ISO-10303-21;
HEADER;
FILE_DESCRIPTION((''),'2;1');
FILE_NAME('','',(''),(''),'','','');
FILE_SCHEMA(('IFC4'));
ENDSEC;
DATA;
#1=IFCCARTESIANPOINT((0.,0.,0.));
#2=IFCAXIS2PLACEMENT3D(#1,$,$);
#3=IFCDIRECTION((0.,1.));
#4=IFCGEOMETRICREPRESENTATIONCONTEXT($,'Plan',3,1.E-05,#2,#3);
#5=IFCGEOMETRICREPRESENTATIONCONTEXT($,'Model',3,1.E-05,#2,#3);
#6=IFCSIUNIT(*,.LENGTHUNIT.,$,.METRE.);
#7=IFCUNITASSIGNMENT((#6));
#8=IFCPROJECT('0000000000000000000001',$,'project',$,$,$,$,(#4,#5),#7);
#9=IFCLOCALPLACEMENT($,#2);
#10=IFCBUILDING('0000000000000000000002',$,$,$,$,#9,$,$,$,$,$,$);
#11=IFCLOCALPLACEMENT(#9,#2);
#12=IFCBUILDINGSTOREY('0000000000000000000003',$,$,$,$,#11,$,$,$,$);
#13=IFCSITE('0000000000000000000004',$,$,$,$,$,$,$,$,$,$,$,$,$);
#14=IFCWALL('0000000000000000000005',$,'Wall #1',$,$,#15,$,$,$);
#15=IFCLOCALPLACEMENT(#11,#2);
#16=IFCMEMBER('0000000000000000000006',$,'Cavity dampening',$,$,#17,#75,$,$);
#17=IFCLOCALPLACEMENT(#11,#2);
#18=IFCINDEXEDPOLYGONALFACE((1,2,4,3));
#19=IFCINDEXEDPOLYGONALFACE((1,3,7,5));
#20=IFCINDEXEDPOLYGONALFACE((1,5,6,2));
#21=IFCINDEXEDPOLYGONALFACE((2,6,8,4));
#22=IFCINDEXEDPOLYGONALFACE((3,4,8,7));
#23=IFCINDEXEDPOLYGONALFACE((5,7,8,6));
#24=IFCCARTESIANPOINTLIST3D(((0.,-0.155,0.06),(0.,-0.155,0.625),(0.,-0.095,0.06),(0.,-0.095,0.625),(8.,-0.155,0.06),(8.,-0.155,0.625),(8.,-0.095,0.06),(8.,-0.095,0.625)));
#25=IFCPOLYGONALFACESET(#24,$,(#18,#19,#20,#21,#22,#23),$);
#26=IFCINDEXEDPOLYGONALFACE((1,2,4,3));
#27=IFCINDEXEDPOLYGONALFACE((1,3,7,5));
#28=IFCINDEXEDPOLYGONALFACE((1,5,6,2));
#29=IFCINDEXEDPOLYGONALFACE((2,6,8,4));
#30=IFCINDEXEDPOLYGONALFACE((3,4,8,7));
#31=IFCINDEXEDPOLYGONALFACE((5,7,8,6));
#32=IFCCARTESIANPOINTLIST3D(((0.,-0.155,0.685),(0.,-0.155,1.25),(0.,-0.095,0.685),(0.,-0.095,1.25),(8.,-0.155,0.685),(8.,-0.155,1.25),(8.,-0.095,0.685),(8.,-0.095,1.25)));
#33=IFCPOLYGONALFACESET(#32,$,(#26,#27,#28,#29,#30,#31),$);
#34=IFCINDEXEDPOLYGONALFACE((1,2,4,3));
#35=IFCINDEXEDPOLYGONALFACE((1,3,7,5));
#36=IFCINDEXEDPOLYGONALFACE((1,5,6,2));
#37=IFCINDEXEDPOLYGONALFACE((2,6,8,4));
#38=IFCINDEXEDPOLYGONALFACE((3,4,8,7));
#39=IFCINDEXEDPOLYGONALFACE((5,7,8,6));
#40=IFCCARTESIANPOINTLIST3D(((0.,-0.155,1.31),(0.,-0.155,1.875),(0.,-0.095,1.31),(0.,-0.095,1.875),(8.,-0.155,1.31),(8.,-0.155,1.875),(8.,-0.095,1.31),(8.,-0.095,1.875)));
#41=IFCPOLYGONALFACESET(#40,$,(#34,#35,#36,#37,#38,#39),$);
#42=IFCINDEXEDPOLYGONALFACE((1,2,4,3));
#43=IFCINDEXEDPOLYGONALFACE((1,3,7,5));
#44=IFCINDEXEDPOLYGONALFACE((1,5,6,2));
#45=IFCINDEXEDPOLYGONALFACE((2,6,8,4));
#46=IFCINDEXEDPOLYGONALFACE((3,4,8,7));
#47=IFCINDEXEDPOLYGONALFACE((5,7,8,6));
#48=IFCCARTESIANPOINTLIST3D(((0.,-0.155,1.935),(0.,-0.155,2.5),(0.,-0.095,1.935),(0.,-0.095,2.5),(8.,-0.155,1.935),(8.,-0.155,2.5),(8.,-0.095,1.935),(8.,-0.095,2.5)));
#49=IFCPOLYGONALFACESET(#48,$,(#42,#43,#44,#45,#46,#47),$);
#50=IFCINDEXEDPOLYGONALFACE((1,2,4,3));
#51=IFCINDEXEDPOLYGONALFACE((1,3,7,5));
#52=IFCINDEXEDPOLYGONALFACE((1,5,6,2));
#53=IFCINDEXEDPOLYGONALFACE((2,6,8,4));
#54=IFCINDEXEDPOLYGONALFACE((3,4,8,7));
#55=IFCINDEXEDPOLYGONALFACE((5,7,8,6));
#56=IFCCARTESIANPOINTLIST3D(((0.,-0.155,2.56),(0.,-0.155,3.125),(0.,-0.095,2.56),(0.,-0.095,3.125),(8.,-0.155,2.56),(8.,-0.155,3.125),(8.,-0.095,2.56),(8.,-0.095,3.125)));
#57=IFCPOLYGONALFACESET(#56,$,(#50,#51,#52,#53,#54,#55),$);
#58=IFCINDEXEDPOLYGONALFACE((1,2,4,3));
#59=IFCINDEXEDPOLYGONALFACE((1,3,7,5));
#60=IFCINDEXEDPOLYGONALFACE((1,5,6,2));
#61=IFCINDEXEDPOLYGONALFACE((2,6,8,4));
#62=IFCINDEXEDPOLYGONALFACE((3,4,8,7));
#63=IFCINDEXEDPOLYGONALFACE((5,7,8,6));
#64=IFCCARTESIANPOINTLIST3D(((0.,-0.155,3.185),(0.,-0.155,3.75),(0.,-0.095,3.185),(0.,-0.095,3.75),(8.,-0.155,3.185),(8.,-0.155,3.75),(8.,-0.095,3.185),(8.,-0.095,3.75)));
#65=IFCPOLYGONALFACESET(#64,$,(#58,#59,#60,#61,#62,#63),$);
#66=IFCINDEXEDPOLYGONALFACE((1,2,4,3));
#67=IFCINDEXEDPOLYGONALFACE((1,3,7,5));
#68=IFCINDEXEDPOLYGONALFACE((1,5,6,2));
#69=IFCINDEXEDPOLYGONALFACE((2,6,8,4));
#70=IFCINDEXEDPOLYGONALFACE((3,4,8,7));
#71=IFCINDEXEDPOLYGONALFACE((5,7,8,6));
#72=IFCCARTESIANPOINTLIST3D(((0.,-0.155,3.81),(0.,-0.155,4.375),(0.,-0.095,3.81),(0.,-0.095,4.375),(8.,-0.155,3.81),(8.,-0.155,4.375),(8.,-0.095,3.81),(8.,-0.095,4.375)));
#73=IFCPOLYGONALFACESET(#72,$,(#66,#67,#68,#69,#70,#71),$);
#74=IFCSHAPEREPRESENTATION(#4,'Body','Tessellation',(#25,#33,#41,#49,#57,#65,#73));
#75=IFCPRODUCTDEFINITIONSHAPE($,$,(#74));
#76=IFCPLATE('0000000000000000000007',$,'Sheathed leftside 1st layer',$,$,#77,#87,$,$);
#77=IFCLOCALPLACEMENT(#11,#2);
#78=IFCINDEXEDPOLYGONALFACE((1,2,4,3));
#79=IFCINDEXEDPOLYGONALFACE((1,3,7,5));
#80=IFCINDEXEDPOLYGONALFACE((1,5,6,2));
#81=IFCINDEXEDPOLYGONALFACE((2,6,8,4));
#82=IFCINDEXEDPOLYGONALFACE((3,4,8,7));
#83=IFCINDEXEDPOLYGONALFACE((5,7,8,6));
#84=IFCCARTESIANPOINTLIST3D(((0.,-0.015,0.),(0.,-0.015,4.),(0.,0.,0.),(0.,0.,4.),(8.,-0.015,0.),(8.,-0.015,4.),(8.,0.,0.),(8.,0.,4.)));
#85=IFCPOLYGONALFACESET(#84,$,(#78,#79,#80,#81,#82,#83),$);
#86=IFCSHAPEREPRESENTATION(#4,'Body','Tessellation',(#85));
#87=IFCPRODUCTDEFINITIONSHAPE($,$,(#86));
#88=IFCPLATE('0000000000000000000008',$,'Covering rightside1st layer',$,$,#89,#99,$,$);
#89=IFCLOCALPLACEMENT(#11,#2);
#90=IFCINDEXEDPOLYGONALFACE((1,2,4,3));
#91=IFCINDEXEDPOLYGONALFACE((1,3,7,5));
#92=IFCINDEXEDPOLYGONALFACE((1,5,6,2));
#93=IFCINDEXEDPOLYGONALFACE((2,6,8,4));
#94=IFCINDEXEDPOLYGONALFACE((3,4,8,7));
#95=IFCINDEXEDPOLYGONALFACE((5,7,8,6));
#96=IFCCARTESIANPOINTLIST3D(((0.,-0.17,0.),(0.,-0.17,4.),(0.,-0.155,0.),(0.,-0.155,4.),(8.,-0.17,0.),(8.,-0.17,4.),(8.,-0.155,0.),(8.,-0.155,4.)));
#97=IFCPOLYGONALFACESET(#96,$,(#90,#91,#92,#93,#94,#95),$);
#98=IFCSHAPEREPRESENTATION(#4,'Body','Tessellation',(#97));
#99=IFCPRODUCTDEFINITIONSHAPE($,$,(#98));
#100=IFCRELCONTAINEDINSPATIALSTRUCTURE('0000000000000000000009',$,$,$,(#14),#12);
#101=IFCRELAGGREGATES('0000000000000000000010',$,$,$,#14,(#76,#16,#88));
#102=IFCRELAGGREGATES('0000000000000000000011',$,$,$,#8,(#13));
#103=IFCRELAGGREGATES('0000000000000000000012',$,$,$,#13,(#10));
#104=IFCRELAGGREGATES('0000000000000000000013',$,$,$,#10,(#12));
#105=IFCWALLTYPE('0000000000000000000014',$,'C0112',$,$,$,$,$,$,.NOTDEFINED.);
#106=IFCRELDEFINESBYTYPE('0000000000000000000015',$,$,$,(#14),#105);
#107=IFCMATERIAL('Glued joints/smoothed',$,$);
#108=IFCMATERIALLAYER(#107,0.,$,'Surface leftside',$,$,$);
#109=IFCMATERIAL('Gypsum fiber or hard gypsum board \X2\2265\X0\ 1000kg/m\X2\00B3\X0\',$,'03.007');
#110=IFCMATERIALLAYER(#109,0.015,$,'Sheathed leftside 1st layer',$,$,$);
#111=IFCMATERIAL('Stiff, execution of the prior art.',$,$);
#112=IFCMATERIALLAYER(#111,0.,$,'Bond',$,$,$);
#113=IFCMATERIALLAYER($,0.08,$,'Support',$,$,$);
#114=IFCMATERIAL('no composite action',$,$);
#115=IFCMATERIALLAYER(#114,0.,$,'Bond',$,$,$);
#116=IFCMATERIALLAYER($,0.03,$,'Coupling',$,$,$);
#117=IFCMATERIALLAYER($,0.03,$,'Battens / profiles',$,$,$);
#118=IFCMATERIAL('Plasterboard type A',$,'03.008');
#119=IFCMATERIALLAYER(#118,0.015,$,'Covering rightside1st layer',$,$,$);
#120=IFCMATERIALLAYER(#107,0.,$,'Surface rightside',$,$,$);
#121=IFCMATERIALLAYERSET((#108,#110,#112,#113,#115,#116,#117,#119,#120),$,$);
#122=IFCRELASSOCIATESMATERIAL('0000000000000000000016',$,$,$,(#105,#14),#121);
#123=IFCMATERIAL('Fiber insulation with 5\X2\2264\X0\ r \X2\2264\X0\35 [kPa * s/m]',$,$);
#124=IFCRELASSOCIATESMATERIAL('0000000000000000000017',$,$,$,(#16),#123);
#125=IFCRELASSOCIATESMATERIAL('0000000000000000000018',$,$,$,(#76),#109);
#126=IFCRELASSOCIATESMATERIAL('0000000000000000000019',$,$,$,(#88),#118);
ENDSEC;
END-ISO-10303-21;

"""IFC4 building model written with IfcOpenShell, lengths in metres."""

from ifc_helpers import new_model, si_unit, direction, frame, frame_2d, origin, origin_with_axes, place, context, project, spatial, rectangle, extrude, material, layer, layer_set, type_object, element, aggregate, save


model = new_model("IFC4")

# Units and contexts
plan_context = context("Plan", 3, precision=1e-05, world=origin(), true_north=direction((0.0, 1.0)))
model_context = context("Model", 3, precision=1e-05, world=origin(), true_north=direction((0.0, 1.0)))
ifc_project = project(units=[si_unit("LENGTHUNIT", "METRE")], contexts=[plan_context, model_context])

# Site, building, storey
site = spatial("IfcSite", under=ifc_project)
building_placement = place(None, origin())
building = spatial("IfcBuilding", under=site, at=building_placement)
storey_placement = place(building_placement, origin())
storey = spatial("IfcBuildingStorey", under=building, at=storey_placement)

# Wall, member, plates
ifc_material_1 = material(Name="Glued joints/smoothed")
ifc_layer_1 = layer(ifc_material_1, 0.0, Name="Surface leftside")
ifc_material_2 = material(Name="Gypsum fiber or hard gypsum board ≥ 1000kg/m³", Category="03.007")
ifc_layer_2 = layer(ifc_material_2, 0.015, Name="Sheathed leftside 1st layer")
ifc_material_3 = material(Name="Stiff, execution of the prior art.")
ifc_layer_3 = layer(ifc_material_3, 0.0, Name="Bond")
ifc_layer_4 = layer(None, 0.08, Name="Support")
ifc_material_4 = material(Name="no composite action")
ifc_layer_5 = layer(ifc_material_4, 0.0, Name="Bond")
ifc_layer_6 = layer(None, 0.03, Name="Coupling")
ifc_layer_7 = layer(None, 0.03, Name="Battens / profiles")
ifc_material_5 = material(Name="Plasterboard type A", Category="03.008")
ifc_layer_8 = layer(ifc_material_5, 0.015, Name="Covering rightside1st layer")
ifc_layer_9 = layer(ifc_material_1, 0.0, Name="Surface rightside")
ifc_layer_set = layer_set([ifc_layer_1, ifc_layer_2, ifc_layer_3, ifc_layer_4, ifc_layer_5, ifc_layer_6, ifc_layer_7, ifc_layer_8, ifc_layer_9])
wall_type = type_object("IfcWallType", Name="C0112", PredefinedType="NOTDEFINED", material=ifc_layer_set)
wall_placement = place(None, frame((0.0, 0.0, 0.0), z_axis=(0.0, -1.0, 0.0), x_axis=(1.0, 0.0, 0.0)))
wall = element("IfcWall", 1, at=wall_placement, inside=storey, type_object=wall_type, material=ifc_layer_set, Name="Wall #1")
ifc_material_6 = material(Name="Fiber insulation with 5≤ r ≤35 [kPa * s/m]")
member_1_placement = place(wall_placement, origin())
member_1 = element("IfcMember", 2, at=member_1_placement, material=ifc_material_6, Name="Cavity dampening", context=plan_context, shape_type="SweptSolid", body=[
    extrude(rectangle(XDim=0.565, YDim=0.06, at=frame_2d((0.2825, 0.03), x_axis=(1.0, 0.0))), frame((0.0, 0.06, 0.095), z_axis=(1.0, 0.0, 0.0), x_axis=(0.0, 1.0, 0.0)), (0.0, 0.0, 1.0), 8.0),
    extrude(rectangle(XDim=0.565, YDim=0.06, at=frame_2d((0.2825, 0.03), x_axis=(1.0, 0.0))), frame((0.0, 0.685, 0.095), z_axis=(1.0, 0.0, 0.0), x_axis=(0.0, 1.0, 0.0)), (0.0, 0.0, 1.0), 8.0),
    extrude(rectangle(XDim=0.565, YDim=0.06, at=frame_2d((0.2825, 0.03), x_axis=(1.0, 0.0))), frame((0.0, 1.31, 0.095), z_axis=(1.0, 0.0, 0.0), x_axis=(0.0, 1.0, 0.0)), (0.0, 0.0, 1.0), 8.0),
    extrude(rectangle(XDim=0.565, YDim=0.06, at=frame_2d((0.2825, 0.03), x_axis=(1.0, 0.0))), frame((0.0, 1.935, 0.095), z_axis=(1.0, 0.0, 0.0), x_axis=(0.0, 1.0, 0.0)), (0.0, 0.0, 1.0), 8.0),
    extrude(rectangle(XDim=0.565, YDim=0.06, at=frame_2d((0.2825, 0.03), x_axis=(1.0, 0.0))), frame((0.0, 2.56, 0.095), z_axis=(1.0, 0.0, 0.0), x_axis=(0.0, 1.0, 0.0)), (0.0, 0.0, 1.0), 8.0),
    extrude(rectangle(XDim=0.565, YDim=0.06, at=frame_2d((0.2825, 0.03), x_axis=(1.0, 0.0))), frame((0.0, 3.185, 0.095), z_axis=(1.0, 0.0, 0.0), x_axis=(0.0, 1.0, 0.0)), (0.0, 0.0, 1.0), 8.0),
    extrude(rectangle(XDim=0.565, YDim=0.06, at=frame_2d((0.2825, 0.03), x_axis=(1.0, 0.0))), frame((0.0, 3.81, 0.095), z_axis=(1.0, 0.0, 0.0), x_axis=(0.0, 1.0, 0.0)), (0.0, 0.0, 1.0), 8.0),
])
plate_1_placement = place(wall_placement, origin())
plate_1 = element("IfcPlate", 3, at=plate_1_placement, material=ifc_material_2, Name="Sheathed leftside 1st layer", context=plan_context, shape_type="SweptSolid", body=[
    extrude(rectangle(XDim=8.0, YDim=4.0, at=frame_2d((4.0, 2.0), x_axis=(1.0, 0.0))), origin_with_axes(), (0.0, 0.0, 1.0), 0.015),
])
plate_2_placement = place(wall_placement, origin())
plate_2 = element("IfcPlate", 4, at=plate_2_placement, material=ifc_material_5, Name="Covering rightside1st layer", context=plan_context, shape_type="SweptSolid", body=[
    extrude(rectangle(XDim=8.0, YDim=4.0, at=frame_2d((4.0, 2.0), x_axis=(1.0, 0.0))), frame((0.0, 0.0, 0.155), z_axis=(0.0, 0.0, 1.0), x_axis=(1.0, 0.0, 0.0)), (0.0, 0.0, 1.0), 0.015),
])
aggregate(wall, [plate_1, member_1, plate_2])

save(model, "model.ifc")
